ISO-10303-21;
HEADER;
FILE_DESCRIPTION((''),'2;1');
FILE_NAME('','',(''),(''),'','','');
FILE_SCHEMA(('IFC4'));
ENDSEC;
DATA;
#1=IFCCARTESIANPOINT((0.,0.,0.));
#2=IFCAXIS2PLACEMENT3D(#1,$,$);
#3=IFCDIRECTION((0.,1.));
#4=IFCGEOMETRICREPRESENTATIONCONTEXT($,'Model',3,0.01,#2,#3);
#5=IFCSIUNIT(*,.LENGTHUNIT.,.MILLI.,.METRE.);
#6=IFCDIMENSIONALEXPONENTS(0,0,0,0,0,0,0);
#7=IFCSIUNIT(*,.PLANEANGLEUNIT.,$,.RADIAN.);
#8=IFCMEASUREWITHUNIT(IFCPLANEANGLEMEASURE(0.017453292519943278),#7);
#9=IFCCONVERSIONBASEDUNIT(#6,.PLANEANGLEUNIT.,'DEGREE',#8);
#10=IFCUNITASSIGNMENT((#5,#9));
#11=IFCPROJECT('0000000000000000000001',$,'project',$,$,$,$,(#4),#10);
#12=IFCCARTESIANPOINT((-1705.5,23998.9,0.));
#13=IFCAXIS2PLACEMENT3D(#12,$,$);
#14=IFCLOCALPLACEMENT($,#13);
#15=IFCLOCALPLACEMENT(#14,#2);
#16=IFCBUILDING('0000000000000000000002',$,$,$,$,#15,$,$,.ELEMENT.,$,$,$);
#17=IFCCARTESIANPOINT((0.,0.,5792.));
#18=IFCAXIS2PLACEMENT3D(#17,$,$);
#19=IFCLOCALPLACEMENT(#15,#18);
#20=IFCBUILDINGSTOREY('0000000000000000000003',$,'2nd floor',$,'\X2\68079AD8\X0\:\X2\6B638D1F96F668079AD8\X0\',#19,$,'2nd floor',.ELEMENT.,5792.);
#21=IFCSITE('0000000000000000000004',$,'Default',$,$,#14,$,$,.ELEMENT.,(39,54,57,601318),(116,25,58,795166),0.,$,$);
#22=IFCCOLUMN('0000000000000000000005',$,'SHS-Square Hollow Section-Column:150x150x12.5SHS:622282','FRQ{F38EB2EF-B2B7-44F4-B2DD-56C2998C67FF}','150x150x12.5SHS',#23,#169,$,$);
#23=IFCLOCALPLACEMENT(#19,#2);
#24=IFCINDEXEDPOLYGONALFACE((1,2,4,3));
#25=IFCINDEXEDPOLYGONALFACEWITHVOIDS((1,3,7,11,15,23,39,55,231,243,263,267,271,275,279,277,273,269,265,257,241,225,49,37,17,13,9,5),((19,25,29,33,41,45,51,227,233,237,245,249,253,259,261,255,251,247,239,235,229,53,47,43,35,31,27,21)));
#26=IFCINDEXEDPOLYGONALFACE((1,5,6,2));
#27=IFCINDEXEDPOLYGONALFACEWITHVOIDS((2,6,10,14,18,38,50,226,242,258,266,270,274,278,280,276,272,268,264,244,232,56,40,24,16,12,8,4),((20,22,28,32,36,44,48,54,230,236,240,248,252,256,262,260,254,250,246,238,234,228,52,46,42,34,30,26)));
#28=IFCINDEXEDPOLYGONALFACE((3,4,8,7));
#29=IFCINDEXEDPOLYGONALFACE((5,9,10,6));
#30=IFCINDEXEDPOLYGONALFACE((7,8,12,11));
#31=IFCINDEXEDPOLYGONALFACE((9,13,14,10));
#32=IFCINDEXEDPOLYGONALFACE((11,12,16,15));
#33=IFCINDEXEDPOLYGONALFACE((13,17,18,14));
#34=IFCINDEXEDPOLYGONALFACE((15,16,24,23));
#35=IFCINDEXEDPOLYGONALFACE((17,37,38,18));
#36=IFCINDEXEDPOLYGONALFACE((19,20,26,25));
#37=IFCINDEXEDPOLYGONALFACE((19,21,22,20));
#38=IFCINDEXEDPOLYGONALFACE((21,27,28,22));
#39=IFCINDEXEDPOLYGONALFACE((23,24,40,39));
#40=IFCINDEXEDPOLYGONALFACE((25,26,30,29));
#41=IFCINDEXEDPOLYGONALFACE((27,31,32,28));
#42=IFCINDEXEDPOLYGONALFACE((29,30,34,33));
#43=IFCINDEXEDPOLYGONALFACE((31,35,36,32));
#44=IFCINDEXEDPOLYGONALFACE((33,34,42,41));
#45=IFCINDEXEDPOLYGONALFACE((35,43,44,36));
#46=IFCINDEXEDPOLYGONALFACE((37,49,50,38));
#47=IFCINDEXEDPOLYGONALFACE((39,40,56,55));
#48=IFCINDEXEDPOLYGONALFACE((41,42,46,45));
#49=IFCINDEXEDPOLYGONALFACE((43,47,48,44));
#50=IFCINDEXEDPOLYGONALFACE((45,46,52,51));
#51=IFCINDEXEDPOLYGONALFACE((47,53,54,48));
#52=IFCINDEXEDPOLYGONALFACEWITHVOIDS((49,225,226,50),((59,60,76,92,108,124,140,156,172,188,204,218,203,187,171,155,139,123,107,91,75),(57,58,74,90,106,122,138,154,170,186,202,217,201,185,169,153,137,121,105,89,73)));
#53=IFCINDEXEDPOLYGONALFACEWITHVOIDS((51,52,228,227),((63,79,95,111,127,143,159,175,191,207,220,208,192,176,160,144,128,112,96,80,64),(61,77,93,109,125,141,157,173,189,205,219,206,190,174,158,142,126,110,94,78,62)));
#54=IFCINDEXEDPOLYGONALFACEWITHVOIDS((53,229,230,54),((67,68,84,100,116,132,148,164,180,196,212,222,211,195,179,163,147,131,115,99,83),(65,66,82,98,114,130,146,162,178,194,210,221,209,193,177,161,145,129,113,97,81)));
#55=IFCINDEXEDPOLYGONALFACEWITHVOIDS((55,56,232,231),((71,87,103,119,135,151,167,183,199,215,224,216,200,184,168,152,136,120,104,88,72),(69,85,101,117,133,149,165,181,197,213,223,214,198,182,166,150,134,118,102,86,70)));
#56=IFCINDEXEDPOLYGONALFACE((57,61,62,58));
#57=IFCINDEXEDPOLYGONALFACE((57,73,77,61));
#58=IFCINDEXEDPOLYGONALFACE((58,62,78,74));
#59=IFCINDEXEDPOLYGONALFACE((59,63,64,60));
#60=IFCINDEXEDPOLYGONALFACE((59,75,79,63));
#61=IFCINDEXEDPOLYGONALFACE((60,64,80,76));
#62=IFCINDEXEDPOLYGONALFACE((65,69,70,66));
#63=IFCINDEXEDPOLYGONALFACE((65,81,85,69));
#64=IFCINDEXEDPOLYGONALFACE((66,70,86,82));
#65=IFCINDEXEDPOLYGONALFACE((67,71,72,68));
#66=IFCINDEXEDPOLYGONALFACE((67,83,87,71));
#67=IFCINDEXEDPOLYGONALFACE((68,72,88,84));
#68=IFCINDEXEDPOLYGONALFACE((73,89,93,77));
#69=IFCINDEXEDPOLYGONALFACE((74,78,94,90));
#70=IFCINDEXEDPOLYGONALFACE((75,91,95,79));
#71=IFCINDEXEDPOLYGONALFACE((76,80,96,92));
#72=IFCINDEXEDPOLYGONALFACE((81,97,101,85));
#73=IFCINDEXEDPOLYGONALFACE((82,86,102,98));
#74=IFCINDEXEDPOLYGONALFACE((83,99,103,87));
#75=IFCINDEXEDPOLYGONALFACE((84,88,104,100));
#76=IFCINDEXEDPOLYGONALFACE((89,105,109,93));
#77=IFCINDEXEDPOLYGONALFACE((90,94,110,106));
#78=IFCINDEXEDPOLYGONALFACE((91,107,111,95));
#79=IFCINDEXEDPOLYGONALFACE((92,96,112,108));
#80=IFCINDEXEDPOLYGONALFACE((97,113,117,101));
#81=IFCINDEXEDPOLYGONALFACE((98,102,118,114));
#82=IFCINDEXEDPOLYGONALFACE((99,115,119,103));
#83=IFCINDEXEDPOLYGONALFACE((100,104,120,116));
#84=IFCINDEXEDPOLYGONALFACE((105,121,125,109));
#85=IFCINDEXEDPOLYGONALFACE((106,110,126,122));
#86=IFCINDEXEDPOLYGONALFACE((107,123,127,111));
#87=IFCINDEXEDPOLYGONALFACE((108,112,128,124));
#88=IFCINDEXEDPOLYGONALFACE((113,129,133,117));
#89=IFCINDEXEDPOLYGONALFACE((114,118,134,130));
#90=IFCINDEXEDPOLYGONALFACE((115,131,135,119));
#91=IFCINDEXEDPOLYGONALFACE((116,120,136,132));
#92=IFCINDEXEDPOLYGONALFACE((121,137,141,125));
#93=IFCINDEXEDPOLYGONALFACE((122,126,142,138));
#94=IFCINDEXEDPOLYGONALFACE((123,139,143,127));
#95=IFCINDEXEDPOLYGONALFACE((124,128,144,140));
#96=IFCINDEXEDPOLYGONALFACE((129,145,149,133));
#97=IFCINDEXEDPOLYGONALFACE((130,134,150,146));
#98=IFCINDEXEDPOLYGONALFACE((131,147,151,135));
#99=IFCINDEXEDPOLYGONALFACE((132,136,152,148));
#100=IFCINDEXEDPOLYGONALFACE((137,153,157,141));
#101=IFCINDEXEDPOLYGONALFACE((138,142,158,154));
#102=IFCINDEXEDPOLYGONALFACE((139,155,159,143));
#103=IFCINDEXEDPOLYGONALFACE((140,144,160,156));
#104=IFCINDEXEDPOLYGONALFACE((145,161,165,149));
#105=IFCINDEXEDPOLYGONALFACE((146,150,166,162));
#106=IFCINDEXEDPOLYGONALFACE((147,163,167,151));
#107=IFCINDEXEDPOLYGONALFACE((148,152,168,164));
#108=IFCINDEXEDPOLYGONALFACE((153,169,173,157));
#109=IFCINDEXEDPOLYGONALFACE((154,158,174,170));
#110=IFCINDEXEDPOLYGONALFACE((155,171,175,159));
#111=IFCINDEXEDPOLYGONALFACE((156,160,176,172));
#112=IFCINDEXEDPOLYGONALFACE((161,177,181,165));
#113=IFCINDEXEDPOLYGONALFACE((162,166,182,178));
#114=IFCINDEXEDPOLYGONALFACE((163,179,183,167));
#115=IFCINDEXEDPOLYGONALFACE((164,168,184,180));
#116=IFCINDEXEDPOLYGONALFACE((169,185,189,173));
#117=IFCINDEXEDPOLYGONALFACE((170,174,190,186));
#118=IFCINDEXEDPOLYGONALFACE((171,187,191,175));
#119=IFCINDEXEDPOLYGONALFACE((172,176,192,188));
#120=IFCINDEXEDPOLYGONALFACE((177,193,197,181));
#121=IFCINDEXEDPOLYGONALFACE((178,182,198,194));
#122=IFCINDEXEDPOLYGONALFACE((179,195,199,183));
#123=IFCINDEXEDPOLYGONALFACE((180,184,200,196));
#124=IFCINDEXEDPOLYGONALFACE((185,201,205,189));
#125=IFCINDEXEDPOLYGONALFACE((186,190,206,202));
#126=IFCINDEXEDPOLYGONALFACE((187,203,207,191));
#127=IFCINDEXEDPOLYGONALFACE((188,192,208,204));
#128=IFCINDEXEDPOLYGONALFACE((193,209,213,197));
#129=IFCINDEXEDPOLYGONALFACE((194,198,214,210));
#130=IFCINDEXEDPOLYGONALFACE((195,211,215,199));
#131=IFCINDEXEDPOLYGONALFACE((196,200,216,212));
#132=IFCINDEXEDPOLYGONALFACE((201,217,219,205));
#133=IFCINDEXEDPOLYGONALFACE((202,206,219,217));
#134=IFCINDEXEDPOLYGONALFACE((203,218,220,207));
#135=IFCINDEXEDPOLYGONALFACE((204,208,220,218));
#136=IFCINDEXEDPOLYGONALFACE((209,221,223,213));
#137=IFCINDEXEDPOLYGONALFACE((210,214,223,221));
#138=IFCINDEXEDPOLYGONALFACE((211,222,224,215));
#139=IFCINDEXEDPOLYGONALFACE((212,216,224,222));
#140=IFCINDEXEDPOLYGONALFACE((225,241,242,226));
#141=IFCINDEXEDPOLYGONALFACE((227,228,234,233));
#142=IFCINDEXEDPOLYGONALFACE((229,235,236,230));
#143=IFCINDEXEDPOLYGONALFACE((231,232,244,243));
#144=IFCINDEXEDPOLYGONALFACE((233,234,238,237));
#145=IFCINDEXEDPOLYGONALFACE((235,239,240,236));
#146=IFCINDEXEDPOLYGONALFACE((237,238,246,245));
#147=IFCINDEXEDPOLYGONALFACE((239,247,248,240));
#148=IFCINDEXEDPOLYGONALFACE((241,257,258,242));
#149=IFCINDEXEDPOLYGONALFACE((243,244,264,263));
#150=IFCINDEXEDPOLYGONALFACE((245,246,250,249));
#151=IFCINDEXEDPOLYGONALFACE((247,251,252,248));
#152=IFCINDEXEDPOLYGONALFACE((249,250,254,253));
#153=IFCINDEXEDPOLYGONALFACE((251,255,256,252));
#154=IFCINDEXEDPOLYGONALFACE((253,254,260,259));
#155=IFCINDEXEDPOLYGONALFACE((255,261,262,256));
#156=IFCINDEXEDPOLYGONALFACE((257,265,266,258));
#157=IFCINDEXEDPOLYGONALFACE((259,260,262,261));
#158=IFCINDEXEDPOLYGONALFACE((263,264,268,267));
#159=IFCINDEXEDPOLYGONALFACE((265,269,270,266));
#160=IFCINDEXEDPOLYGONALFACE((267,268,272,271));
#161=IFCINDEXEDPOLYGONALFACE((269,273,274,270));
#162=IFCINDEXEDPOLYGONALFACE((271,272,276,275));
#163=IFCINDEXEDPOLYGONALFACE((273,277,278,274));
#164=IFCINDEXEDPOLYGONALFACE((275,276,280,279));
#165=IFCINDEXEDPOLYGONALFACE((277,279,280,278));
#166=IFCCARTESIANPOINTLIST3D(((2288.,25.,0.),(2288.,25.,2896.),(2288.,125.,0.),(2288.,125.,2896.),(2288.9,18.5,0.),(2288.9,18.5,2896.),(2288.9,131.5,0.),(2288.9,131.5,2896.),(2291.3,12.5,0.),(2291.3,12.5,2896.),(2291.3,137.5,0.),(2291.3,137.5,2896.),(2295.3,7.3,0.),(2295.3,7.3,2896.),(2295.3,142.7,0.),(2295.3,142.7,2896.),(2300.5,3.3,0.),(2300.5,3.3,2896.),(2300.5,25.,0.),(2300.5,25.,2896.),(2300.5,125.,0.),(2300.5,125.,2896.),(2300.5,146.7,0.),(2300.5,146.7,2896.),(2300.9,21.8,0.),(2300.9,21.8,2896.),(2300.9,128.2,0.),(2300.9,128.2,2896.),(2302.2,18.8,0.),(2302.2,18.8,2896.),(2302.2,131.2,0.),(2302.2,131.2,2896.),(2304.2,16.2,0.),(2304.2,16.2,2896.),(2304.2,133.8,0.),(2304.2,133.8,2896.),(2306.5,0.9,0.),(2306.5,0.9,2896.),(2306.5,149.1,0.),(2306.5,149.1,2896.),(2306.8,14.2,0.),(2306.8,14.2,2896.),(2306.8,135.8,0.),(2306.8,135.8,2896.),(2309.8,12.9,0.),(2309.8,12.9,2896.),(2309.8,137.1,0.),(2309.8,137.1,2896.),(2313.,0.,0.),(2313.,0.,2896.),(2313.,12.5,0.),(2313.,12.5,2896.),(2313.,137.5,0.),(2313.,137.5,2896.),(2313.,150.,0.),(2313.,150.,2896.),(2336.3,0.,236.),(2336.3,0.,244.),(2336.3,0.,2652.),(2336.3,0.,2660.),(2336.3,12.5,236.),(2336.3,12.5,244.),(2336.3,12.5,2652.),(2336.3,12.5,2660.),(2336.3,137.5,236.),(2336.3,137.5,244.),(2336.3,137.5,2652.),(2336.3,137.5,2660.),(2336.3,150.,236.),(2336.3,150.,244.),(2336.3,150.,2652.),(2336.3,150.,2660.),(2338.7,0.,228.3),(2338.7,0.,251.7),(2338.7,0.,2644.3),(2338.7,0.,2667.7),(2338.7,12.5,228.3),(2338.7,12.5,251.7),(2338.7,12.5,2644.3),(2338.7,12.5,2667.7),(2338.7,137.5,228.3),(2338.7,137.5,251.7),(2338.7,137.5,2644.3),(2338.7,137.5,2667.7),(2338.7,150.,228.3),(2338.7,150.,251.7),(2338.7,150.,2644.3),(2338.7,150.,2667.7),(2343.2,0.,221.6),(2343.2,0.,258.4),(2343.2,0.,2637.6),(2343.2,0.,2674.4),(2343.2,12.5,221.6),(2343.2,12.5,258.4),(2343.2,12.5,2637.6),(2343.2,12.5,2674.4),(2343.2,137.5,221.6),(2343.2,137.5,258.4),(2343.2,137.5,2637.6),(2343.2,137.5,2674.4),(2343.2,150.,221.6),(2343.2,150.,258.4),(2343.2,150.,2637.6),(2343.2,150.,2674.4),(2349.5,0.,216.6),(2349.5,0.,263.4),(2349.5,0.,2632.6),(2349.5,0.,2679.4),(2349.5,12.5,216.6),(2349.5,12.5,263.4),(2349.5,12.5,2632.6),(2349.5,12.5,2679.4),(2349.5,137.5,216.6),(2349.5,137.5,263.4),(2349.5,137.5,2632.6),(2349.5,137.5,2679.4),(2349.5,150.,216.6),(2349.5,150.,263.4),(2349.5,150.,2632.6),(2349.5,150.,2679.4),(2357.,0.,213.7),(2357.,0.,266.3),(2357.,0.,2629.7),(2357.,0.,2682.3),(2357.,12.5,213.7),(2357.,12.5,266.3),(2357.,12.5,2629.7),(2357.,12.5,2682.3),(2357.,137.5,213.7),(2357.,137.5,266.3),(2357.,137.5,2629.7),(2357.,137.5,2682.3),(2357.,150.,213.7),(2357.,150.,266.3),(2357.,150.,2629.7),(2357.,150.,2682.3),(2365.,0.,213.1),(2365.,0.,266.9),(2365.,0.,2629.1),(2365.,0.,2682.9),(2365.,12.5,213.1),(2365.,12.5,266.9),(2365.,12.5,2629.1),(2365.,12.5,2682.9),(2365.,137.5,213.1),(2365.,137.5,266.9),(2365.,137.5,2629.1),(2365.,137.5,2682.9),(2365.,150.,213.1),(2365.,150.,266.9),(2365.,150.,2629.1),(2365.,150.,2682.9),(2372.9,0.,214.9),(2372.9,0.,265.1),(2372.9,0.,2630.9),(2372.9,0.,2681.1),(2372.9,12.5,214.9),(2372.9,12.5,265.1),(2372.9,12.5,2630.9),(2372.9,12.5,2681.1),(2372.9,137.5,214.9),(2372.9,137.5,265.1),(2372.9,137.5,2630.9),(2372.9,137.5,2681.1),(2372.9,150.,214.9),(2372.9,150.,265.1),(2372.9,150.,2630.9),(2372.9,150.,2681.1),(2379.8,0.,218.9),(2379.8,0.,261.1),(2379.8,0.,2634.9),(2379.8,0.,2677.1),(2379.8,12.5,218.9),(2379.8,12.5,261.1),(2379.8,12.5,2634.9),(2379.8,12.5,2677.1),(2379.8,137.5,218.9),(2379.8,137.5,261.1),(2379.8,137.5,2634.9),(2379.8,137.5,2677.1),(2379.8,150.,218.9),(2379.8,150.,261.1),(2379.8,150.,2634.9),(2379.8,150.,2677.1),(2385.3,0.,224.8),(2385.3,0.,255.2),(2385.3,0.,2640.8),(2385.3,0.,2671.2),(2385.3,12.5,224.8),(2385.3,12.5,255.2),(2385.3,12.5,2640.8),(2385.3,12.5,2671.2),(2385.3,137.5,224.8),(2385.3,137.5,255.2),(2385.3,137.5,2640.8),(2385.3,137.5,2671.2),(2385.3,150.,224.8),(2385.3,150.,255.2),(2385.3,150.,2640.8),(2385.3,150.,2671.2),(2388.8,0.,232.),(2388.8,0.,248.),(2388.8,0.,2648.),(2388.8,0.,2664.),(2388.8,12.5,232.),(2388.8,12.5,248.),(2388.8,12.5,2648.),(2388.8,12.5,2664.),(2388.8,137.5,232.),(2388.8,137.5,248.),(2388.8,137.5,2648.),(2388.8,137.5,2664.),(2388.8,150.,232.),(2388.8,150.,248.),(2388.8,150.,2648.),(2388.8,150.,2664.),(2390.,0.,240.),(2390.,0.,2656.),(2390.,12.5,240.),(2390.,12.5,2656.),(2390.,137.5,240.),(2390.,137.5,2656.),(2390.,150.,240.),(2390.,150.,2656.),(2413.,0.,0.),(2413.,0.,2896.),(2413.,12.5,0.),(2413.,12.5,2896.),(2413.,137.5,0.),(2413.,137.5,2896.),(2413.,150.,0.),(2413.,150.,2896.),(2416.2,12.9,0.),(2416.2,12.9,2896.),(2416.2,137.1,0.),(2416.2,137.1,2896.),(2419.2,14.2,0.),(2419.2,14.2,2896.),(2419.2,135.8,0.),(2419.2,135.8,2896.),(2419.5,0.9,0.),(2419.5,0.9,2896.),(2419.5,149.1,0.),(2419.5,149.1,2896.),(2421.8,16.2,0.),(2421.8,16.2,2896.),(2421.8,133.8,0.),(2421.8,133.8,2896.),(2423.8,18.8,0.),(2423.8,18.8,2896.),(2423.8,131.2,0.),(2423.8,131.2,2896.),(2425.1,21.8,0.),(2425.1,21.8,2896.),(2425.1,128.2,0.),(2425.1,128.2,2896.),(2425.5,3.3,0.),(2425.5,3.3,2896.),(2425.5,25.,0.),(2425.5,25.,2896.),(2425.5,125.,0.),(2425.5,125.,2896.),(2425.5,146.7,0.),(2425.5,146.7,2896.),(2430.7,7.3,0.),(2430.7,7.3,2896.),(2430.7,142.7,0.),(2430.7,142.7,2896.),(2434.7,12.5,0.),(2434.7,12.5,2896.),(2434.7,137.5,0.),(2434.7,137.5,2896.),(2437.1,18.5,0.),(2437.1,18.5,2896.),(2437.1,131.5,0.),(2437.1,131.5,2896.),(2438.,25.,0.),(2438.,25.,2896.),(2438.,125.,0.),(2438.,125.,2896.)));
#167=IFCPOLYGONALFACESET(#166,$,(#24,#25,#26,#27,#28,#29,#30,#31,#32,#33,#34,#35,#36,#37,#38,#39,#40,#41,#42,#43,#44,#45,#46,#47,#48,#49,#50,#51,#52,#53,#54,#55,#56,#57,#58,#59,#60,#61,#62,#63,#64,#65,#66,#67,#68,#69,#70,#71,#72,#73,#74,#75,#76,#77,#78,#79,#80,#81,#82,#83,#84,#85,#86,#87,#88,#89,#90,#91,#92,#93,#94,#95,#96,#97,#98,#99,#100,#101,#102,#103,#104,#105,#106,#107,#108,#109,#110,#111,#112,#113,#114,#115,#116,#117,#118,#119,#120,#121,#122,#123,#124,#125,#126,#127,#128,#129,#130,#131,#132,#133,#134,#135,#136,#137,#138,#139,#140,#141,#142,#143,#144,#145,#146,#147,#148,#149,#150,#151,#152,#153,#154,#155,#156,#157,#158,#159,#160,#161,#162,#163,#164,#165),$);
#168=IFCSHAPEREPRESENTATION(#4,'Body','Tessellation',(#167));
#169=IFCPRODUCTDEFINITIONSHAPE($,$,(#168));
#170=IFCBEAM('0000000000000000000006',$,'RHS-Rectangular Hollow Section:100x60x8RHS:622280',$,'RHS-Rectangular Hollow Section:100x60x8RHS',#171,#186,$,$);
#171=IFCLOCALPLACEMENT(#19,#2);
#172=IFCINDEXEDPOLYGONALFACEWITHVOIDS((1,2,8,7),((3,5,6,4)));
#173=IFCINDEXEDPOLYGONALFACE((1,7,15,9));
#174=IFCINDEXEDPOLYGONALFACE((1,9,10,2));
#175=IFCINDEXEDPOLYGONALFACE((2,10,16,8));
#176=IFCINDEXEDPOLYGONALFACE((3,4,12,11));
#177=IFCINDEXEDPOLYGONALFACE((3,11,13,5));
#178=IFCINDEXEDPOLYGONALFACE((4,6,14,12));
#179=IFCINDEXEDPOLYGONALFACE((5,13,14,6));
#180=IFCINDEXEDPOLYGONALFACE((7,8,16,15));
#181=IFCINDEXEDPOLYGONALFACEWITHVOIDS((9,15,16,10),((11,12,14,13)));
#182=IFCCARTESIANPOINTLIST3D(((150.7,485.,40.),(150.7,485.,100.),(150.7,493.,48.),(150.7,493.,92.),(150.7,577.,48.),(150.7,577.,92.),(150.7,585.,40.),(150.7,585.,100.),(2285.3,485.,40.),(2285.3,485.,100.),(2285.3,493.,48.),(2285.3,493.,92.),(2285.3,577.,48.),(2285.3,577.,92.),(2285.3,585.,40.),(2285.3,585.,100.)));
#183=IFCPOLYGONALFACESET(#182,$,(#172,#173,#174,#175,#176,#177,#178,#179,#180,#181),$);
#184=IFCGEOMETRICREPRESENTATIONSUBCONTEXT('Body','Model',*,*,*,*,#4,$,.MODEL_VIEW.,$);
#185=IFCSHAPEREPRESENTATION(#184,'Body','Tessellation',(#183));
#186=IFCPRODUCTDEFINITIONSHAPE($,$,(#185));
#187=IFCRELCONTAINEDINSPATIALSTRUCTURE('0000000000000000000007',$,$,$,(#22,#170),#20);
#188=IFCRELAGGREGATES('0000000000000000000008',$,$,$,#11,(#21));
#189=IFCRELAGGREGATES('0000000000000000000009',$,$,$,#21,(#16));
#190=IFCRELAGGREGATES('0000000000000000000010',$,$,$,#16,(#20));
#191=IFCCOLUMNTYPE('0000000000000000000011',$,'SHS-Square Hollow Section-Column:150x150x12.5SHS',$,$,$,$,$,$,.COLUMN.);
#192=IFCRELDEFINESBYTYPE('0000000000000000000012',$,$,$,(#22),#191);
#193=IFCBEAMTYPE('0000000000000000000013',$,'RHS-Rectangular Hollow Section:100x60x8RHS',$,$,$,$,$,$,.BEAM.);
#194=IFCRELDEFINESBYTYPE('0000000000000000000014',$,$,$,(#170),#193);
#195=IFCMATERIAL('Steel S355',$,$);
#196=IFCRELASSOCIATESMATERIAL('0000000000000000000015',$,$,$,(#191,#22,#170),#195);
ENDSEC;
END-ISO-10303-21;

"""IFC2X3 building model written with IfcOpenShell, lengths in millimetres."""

from ifc_helpers import new_model, entity, si_unit, converted_unit, direction, frame, frame_2d, origin, origin_2d, place, context, subcontext, project, spatial, circle_curve, rectangle, hollow_rectangle, outline, extrude, boolean, material, type_object, element, save


model = new_model("IFC2X3")

# Units and contexts
model_context = context("Model", 3, precision=0.01, world=origin(), true_north=direction((0.0, 1.0)))
body_context = subcontext(model_context, "Body", "Model", "MODEL_VIEW")
ifc_project = project(units=[si_unit("LENGTHUNIT", "METRE", prefix="MILLI"), converted_unit("PLANEANGLEUNIT", "DEGREE", entity("IfcPlaneAngleMeasure", 0.017453292519943278), si_unit("PLANEANGLEUNIT", "RADIAN"), dimensions=[0, 0, 0, 0, 0, 0, 0])], contexts=[model_context])

# Site, building, storey
site_placement = place(None, frame((-1705.5, 23998.9, 0.0)))
site = spatial("IfcSite", under=ifc_project, at=site_placement, Name="Default", CompositionType="ELEMENT", RefLatitude=(39, 54, 57, 601318), RefLongitude=(116, 25, 58, 795166), RefElevation=0.0)
building_placement = place(site_placement, origin())
building = spatial("IfcBuilding", under=site, at=building_placement, CompositionType="ELEMENT")
storey_placement = place(building_placement, frame((0.0, 0.0, 5792.0)))
storey = spatial("IfcBuildingStorey", under=building, at=storey_placement, Name="2nd floor", ObjectType="标高:正负零标高", LongName="2nd floor", CompositionType="ELEMENT", Elevation=5792.0)

# Shared definitions
ifc_material_1 = material(Name="Steel S355")

# Column, openings
column_type_1 = type_object("IfcColumnType", Name="SHS-Square Hollow Section-Column:150x150x12.5SHS", PredefinedType="COLUMN", material=ifc_material_1)
column_1_placement = place(storey_placement, frame((2363.0, 75.0, 2896.0), z_axis=(0.0, 0.0, 1.0), x_axis=(0.0, -1.0, 0.0)))
column_1 = element("IfcColumn", 1, at=column_1_placement, inside=storey, type_object=column_type_1, material=ifc_material_1, Name="SHS-Square Hollow Section-Column:150x150x12.5SHS:622282", Description="FRQ{F38EB2EF-B2B7-44F4-B2DD-56C2998C67FF}", ObjectType="150x150x12.5SHS", context=model_context, shape_type="SweptSolid", body=[
    extrude(hollow_rectangle(XDim=150.0, YDim=150.0, WallThickness=12.5, InnerFilletRadius=12.5, OuterFilletRadius=25.0, at=origin_2d()), origin(), (0.0, 0.0, -1.0), 2896.0),
])
opening_1_placement = place(column_1_placement, frame((-175.1, 0.0, 0.0), z_axis=(1.0, 0.0, 0.0), x_axis=(0.0, 1.0, 0.0)))
element("IfcOpeningElement", 2, at=opening_1_placement, cuts=column_1, ObjectType="Opening", context=model_context, shape_type="SweptSolid", body=[
    extrude(outline(circle_curve(frame_2d((0.0, -240.0), x_axis=(1.0, 0.0)), 27.0)), origin(), (0.0, 0.0, 1.0), 350.2),
])
opening_2_placement = place(column_1_placement, frame((-175.1, 0.0, -2896.0), z_axis=(1.0, 0.0, 0.0), x_axis=(0.0, 1.0, 0.0)))
element("IfcOpeningElement", 3, at=opening_2_placement, cuts=column_1, ObjectType="Opening", context=model_context, shape_type="SweptSolid", body=[
    extrude(outline(circle_curve(frame_2d((0.0, 240.0), x_axis=(1.0, 0.0)), 27.0)), origin(), (0.0, 0.0, 1.0), 350.2),
])

# Beam
beam_type_1 = type_object("IfcBeamType", Name="RHS-Rectangular Hollow Section:100x60x8RHS", PredefinedType="BEAM")
beam_1_placement = place(storey_placement, frame((150.7, 585.0, 70.0)))
element("IfcBeam", 4, at=beam_1_placement, inside=storey, type_object=beam_type_1, material=ifc_material_1, Name="RHS-Rectangular Hollow Section:100x60x8RHS:622280", ObjectType="RHS-Rectangular Hollow Section:100x60x8RHS", context=body_context, shape_type="SweptSolid", body=[
    boolean("DIFFERENCE", extrude(rectangle(XDim=60.0, YDim=100.0, at=frame_2d((0.0, 0.0), x_axis=(1.0, 0.0))), frame((0.0, -50.0, 0.0), z_axis=(1.0, 0.0, 0.0), x_axis=(0.0, 0.0, -1.0)), (0.0, 0.0, 1.0), 2134.6), extrude(rectangle(XDim=44.0, YDim=84.0, at=frame_2d((0.0, 0.0), x_axis=(0.0, 1.0))), frame((2134.6, -50.0, 0.0), z_axis=(-1.0, 0.0, 0.0), x_axis=(0.0, 1.0, 0.0)), (0.0, 0.0, 1.0), 2134.6)),
])

save(model, "model.ifc")
